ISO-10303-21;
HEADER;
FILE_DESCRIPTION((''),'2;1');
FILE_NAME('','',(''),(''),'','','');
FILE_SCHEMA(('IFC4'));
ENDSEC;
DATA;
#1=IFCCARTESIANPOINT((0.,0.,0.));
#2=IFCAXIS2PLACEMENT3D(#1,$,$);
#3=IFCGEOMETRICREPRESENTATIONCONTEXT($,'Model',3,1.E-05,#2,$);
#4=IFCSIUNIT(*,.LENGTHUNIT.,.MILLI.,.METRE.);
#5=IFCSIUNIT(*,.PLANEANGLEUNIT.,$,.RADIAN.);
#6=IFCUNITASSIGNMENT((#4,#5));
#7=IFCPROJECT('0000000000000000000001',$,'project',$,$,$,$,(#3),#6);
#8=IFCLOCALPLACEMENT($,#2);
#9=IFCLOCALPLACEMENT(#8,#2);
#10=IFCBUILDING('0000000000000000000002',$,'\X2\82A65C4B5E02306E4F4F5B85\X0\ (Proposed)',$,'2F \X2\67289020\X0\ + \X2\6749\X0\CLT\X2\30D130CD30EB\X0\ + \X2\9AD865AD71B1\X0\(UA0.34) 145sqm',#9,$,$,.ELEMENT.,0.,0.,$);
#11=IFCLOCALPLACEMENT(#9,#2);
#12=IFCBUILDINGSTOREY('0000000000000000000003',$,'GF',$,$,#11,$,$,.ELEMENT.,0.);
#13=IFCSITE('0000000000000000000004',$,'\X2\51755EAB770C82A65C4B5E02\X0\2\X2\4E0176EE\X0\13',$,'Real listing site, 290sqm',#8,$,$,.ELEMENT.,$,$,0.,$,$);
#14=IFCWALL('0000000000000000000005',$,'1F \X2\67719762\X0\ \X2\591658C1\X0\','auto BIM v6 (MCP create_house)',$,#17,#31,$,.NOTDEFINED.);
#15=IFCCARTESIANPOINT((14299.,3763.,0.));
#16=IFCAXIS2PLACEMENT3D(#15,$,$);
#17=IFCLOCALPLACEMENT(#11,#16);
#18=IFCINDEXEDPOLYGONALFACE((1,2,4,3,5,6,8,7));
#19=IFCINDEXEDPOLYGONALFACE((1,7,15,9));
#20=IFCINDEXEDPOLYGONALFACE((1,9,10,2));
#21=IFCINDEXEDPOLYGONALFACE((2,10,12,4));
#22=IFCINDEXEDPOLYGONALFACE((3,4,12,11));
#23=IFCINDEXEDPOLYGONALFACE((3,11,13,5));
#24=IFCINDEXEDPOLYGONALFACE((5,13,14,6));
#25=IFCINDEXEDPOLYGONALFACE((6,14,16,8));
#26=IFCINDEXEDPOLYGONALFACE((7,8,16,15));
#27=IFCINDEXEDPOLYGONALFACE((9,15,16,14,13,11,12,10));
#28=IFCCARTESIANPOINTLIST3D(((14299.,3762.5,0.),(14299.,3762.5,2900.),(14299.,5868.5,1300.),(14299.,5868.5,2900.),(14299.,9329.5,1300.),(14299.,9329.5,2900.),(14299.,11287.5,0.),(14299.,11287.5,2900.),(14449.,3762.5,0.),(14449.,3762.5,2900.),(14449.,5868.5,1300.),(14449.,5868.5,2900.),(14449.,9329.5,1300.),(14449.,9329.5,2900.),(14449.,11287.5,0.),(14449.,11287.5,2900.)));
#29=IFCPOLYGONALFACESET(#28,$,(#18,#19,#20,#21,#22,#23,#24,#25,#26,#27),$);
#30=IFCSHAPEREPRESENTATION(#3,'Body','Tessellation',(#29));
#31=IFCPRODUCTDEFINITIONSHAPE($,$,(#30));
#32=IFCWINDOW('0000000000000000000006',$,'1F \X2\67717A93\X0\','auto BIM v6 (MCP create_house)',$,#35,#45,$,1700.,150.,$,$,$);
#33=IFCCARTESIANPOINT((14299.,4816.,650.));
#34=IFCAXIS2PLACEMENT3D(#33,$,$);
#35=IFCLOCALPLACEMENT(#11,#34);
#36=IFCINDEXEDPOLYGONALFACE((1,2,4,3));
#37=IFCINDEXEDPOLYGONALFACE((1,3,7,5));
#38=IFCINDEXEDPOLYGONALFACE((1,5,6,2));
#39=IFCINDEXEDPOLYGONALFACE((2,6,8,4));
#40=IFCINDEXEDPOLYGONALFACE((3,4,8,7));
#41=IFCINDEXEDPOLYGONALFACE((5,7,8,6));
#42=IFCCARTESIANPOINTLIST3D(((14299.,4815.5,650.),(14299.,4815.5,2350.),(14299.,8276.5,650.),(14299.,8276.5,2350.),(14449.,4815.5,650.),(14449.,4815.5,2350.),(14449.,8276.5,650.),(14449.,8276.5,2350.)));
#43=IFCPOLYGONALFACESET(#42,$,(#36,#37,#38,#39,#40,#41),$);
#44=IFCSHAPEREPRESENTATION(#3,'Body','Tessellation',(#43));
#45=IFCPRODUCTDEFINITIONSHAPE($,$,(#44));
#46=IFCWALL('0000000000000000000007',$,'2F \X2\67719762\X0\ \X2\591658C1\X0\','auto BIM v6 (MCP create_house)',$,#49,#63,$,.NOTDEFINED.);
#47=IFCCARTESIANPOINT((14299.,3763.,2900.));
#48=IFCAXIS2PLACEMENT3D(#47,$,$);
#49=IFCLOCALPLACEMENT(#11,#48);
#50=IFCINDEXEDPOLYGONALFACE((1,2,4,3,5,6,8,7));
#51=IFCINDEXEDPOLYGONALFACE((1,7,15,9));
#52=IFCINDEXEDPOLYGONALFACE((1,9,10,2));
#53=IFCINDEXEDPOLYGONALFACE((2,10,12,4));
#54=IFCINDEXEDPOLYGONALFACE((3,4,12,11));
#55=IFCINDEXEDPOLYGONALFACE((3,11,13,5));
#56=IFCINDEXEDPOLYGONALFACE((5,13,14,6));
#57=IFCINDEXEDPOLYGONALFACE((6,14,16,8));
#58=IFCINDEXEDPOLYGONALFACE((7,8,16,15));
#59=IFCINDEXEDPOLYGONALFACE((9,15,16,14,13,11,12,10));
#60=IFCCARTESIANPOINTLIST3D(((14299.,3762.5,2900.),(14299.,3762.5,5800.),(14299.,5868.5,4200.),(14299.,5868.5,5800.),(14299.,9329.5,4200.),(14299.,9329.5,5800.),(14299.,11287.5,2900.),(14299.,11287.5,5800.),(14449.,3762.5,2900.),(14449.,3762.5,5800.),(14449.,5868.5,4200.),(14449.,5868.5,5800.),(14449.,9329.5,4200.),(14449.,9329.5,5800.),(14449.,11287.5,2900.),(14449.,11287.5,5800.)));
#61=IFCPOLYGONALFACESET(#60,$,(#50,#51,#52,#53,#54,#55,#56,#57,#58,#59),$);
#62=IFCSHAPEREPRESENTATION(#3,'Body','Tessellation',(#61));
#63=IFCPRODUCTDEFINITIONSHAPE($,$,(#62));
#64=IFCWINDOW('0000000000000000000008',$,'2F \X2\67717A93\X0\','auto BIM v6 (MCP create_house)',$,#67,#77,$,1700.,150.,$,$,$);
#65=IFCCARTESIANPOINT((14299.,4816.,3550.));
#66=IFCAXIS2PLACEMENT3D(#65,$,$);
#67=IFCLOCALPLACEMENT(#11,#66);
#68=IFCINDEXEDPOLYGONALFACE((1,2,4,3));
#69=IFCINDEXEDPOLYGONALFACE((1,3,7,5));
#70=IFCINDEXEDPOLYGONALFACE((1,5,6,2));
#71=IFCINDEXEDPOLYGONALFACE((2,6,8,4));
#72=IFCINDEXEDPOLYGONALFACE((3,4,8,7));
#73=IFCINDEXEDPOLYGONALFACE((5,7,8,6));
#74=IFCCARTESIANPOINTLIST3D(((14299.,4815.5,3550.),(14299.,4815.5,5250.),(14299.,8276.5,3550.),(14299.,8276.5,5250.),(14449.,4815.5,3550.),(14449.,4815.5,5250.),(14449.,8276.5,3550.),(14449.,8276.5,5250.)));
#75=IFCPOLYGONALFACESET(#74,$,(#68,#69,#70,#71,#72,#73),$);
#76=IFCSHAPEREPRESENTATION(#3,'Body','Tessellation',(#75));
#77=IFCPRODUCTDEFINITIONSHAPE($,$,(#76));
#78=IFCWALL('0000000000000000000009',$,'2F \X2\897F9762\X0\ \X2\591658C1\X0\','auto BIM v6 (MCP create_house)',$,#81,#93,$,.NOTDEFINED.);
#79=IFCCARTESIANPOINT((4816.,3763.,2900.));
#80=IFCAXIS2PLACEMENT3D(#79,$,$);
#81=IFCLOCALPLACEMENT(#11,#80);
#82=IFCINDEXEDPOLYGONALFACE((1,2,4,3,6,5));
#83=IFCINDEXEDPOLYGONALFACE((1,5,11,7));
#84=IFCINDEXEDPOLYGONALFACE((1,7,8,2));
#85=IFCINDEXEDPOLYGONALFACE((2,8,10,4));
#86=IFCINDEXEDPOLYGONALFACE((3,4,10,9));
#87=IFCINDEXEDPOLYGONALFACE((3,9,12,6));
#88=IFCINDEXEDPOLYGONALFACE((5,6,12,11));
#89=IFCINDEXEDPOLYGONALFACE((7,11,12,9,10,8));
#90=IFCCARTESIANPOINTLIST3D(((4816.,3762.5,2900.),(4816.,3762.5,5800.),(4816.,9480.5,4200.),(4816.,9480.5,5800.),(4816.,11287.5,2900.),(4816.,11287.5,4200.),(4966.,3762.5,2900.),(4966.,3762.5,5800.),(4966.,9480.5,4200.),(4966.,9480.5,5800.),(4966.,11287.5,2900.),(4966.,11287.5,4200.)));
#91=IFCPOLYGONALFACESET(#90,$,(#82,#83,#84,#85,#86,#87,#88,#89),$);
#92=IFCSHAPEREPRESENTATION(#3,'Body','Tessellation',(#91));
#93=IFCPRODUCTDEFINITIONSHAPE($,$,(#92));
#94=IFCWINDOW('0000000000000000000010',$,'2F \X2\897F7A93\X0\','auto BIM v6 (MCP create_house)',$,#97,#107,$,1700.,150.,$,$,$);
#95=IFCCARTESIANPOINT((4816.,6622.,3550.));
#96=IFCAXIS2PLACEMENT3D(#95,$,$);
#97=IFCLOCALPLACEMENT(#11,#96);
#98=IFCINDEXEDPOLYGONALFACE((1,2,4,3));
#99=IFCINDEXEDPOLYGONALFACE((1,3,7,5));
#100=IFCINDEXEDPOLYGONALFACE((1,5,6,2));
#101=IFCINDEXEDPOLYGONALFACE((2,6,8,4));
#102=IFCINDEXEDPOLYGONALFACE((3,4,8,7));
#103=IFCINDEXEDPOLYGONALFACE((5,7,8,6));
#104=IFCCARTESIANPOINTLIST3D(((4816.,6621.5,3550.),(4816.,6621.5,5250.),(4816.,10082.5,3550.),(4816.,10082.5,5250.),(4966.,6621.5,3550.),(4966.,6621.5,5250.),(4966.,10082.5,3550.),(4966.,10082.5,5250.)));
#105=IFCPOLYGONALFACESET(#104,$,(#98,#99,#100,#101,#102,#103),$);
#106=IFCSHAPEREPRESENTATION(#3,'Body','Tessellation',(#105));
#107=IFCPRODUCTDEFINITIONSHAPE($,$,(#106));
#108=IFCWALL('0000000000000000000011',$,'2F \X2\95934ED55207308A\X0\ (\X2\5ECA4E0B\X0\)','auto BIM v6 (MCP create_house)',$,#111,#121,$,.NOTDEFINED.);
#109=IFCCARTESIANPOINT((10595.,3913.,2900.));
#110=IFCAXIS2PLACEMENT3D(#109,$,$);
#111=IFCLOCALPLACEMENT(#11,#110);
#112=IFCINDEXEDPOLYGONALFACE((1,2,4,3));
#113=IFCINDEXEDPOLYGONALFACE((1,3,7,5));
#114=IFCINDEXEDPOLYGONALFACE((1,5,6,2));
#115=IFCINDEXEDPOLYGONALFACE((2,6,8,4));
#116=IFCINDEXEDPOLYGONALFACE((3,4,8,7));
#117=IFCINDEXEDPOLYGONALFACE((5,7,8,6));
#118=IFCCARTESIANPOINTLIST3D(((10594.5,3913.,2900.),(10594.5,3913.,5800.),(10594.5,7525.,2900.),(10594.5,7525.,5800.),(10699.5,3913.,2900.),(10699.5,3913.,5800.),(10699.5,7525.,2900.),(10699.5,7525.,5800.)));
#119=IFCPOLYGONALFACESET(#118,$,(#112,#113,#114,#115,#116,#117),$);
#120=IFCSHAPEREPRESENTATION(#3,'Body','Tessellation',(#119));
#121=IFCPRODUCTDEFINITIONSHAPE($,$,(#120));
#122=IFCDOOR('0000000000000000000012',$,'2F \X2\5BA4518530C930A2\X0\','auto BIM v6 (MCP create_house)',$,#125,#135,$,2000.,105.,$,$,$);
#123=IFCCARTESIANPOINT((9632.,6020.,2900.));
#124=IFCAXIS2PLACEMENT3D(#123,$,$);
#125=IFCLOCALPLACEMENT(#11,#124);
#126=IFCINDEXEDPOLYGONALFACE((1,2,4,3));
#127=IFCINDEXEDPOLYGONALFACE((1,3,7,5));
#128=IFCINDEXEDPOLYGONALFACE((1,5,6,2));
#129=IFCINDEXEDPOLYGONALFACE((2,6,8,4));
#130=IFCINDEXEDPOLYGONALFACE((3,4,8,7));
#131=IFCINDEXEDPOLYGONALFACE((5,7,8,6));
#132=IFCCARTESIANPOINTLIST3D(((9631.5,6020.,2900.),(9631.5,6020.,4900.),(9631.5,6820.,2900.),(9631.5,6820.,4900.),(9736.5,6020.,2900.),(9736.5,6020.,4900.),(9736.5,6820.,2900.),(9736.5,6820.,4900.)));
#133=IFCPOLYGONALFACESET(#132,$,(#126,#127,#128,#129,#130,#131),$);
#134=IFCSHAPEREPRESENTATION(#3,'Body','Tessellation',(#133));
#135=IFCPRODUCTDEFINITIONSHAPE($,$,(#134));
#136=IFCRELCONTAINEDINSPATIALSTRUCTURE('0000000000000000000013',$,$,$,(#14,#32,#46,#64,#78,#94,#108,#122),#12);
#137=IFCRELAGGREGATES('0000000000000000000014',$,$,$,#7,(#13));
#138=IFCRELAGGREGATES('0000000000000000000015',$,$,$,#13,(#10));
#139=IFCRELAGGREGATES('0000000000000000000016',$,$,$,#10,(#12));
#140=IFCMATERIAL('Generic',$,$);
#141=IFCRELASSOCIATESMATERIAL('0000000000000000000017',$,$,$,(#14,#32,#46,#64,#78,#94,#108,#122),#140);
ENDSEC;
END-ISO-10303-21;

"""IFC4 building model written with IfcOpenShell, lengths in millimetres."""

from ifc_helpers import new_model, si_unit, frame, frame_2d, origin, place, context, project, spatial, rectangle, extrude, material, element, fill, save


model = new_model("IFC4")

# Units and contexts
model_context = context("Model", 3, precision=1e-05, world=origin())
ifc_project = project(units=[si_unit("LENGTHUNIT", "METRE", prefix="MILLI"), si_unit("PLANEANGLEUNIT", "RADIAN")], contexts=[model_context])

# Site, building, storey
site_placement = place(None, origin())
site = spatial("IfcSite", under=ifc_project, at=site_placement, Name="兵庫県芦屋市2丁目13", ObjectType="Real listing site, 290sqm", CompositionType="ELEMENT", RefElevation=0.0)
building_placement = place(site_placement, origin())
building = spatial("IfcBuilding", under=site, at=building_placement, Name="芦屋市の住宅 (Proposed)", ObjectType="2F 木造 + 杉CLTパネル + 高断熱(UA0.34) 145sqm", CompositionType="ELEMENT", ElevationOfRefHeight=0.0, ElevationOfTerrain=0.0)
storey_placement = place(building_placement, origin())
storey = spatial("IfcBuildingStorey", under=building, at=storey_placement, Name="GF", CompositionType="ELEMENT", Elevation=0.0)

# Shared definitions
ifc_material = material(Name="Generic")

# Wall, opening, window
wall_1_placement = place(storey_placement, frame((14299.0, 3763.0, 0.0)))
wall_1 = element("IfcWall", 1, at=wall_1_placement, inside=storey, material=ifc_material, Name="1F 東面 外壁", Description="auto BIM v6 (MCP create_house)", PredefinedType="NOTDEFINED", context=model_context, shape_type="SweptSolid", body=[
    extrude(rectangle(XDim=150.0, YDim=7525.0, at=frame_2d((75.0, 3762.0))), frame((14299.0, 3763.0, 0.0)), (0.0, 0.0, 1.0), 2900.0),
])
opening_1_placement = place(storey_placement, frame((14299.0, 4816.0, 650.0)))
opening_1 = element("IfcOpeningElement", 2, at=opening_1_placement, cuts=wall_1, PredefinedType="NOTDEFINED", context=model_context, shape_type="SweptSolid", body=[
    extrude(rectangle(XDim=150.0, YDim=3461.0, at=frame_2d((75.0, 1730.0))), frame((14299.0, 4816.0, 650.0)), (0.0, 0.0, 1.0), 1700.0),
])
window_1_placement = place(storey_placement, frame((14299.0, 4816.0, 650.0)))
window_1 = element("IfcWindow", 3, at=window_1_placement, inside=storey, material=ifc_material, Name="1F 東窓", Description="auto BIM v6 (MCP create_house)", OverallHeight=1700.0, OverallWidth=150.0, context=model_context, shape_type="SweptSolid", body=[
    extrude(rectangle(XDim=150.0, YDim=3461.0, at=frame_2d((75.0, 1730.0))), frame((14299.0, 4816.0, 650.0)), (0.0, 0.0, 1.0), 1700.0),
])
fill(opening_1, window_1)

# Walls, openings, windows
wall_2_placement = place(storey_placement, frame((14299.0, 3763.0, 2900.0)))
wall_2 = element("IfcWall", 4, at=wall_2_placement, inside=storey, material=ifc_material, Name="2F 東面 外壁", Description="auto BIM v6 (MCP create_house)", PredefinedType="NOTDEFINED", context=model_context, shape_type="SweptSolid", body=[
    extrude(rectangle(XDim=150.0, YDim=7525.0, at=frame_2d((75.0, 3762.0))), frame((14299.0, 3763.0, 2900.0)), (0.0, 0.0, 1.0), 2900.0),
])
opening_2_placement = place(storey_placement, frame((14299.0, 4816.0, 3550.0)))
opening_2 = element("IfcOpeningElement", 5, at=opening_2_placement, cuts=wall_2, PredefinedType="NOTDEFINED", context=model_context, shape_type="SweptSolid", body=[
    extrude(rectangle(XDim=150.0, YDim=3461.0, at=frame_2d((75.0, 1730.0))), frame((14299.0, 4816.0, 3550.0)), (0.0, 0.0, 1.0), 1700.0),
])
window_2_placement = place(storey_placement, frame((14299.0, 4816.0, 3550.0)))
window_2 = element("IfcWindow", 6, at=window_2_placement, inside=storey, material=ifc_material, Name="2F 東窓", Description="auto BIM v6 (MCP create_house)", OverallHeight=1700.0, OverallWidth=150.0, context=model_context, shape_type="SweptSolid", body=[
    extrude(rectangle(XDim=150.0, YDim=3461.0, at=frame_2d((75.0, 1730.0))), frame((14299.0, 4816.0, 3550.0)), (0.0, 0.0, 1.0), 1700.0),
])
fill(opening_2, window_2)
wall_3_placement = place(storey_placement, frame((4816.0, 3763.0, 2900.0)))
wall_3 = element("IfcWall", 7, at=wall_3_placement, inside=storey, material=ifc_material, Name="2F 西面 外壁", Description="auto BIM v6 (MCP create_house)", PredefinedType="NOTDEFINED", context=model_context, shape_type="SweptSolid", body=[
    extrude(rectangle(XDim=150.0, YDim=7525.0, at=frame_2d((75.0, 3762.0))), frame((4816.0, 3763.0, 2900.0)), (0.0, 0.0, 1.0), 2900.0),
])
opening_3_placement = place(storey_placement, frame((4816.0, 6622.0, 3550.0)))
opening_3 = element("IfcOpeningElement", 8, at=opening_3_placement, cuts=wall_3, PredefinedType="NOTDEFINED", context=model_context, shape_type="SweptSolid", body=[
    extrude(rectangle(XDim=150.0, YDim=3461.0, at=frame_2d((75.0, 1730.0))), frame((4816.0, 6622.0, 3550.0)), (0.0, 0.0, 1.0), 1700.0),
])
window_3_placement = place(storey_placement, frame((4816.0, 6622.0, 3550.0)))
window_3 = element("IfcWindow", 9, at=window_3_placement, inside=storey, material=ifc_material, Name="2F 西窓", Description="auto BIM v6 (MCP create_house)", OverallHeight=1700.0, OverallWidth=150.0, context=model_context, shape_type="SweptSolid", body=[
    extrude(rectangle(XDim=150.0, YDim=3461.0, at=frame_2d((75.0, 1730.0))), frame((4816.0, 6622.0, 3550.0)), (0.0, 0.0, 1.0), 1700.0),
])
fill(opening_3, window_3)

# Wall
wall_4_placement = place(storey_placement, frame((10595.0, 3913.0, 2900.0)))
element("IfcWall", 10, at=wall_4_placement, inside=storey, material=ifc_material, Name="2F 間仕切り (廊下)", Description="auto BIM v6 (MCP create_house)", PredefinedType="NOTDEFINED", context=model_context, shape_type="SweptSolid", body=[
    extrude(rectangle(XDim=105.0, YDim=3612.0, at=frame_2d((52.0, 1806.0))), frame((10595.0, 3913.0, 2900.0)), (0.0, 0.0, 1.0), 2900.0),
])

# Door
door_placement = place(storey_placement, frame((9632.0, 6020.0, 2900.0)))
element("IfcDoor", 11, at=door_placement, inside=storey, material=ifc_material, Name="2F 室内ドア", Description="auto BIM v6 (MCP create_house)", OverallHeight=2000.0, OverallWidth=105.0, context=model_context, shape_type="SweptSolid", body=[
    extrude(rectangle(XDim=105.0, YDim=800.0, at=frame_2d((52.0, 400.0))), frame((9632.0, 6020.0, 2900.0)), (0.0, 0.0, 1.0), 2000.0),
])

save(model, "model.ifc")
